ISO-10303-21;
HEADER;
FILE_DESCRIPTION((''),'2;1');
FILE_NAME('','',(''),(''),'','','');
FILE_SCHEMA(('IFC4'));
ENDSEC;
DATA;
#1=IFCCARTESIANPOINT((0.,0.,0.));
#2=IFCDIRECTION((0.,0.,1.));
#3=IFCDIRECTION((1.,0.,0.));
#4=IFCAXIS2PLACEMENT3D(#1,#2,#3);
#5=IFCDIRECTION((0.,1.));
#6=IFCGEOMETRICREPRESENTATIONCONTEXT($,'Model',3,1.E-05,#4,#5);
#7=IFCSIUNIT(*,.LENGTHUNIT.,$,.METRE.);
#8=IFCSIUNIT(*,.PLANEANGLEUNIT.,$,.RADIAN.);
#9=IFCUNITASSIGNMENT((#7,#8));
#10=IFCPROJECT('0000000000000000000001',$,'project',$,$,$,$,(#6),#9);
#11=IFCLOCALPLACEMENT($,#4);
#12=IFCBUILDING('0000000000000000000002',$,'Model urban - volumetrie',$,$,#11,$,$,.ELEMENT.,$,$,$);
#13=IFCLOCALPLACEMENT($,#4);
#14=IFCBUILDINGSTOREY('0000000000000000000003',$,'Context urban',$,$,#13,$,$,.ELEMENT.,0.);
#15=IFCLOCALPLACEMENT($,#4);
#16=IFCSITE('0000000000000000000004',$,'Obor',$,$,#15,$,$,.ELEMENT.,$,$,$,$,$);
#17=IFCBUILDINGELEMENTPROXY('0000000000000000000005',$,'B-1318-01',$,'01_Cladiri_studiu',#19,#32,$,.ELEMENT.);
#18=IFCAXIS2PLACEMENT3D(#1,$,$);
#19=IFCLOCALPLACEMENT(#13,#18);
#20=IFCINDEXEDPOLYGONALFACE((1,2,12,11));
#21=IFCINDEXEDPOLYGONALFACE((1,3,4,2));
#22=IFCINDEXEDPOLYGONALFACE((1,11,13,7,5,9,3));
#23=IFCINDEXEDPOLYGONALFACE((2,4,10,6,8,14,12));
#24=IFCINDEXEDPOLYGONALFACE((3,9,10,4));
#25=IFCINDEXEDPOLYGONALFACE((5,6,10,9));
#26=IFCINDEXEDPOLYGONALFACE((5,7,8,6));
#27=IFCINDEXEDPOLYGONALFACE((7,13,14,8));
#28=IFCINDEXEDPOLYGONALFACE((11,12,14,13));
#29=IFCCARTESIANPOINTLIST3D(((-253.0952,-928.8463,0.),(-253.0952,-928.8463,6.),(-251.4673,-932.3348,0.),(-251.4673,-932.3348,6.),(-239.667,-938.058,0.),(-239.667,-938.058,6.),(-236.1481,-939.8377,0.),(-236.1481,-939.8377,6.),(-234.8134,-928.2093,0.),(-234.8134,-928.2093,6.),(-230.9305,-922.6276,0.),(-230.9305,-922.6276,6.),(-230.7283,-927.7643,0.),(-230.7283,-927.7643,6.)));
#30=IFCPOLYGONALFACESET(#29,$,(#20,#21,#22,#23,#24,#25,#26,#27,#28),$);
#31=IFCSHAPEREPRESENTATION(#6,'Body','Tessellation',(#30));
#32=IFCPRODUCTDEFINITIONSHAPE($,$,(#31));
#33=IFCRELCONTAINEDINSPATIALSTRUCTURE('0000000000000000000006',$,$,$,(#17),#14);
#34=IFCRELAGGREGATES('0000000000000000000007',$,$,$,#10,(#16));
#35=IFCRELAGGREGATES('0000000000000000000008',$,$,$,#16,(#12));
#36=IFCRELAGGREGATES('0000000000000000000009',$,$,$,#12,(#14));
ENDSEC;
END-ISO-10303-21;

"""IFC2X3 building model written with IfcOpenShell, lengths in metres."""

from ifc_helpers import new_model, si_unit, direction, origin_with_axes, place, context, project, spatial, polyline, outline, extrude, element, save


model = new_model("IFC2X3")

# Units and contexts
model_context = context("Model", 3, precision=1e-05, world=origin_with_axes(), true_north=direction((0.0, 1.0)))
ifc_project = project(units=[si_unit("LENGTHUNIT", "METRE"), si_unit("PLANEANGLEUNIT", "RADIAN")], contexts=[model_context])

# Site, building, storey
site_placement = place(None, origin_with_axes())
site = spatial("IfcSite", under=ifc_project, at=site_placement, Name="Obor", CompositionType="ELEMENT")
building_placement = place(None, origin_with_axes())
building = spatial("IfcBuilding", under=site, at=building_placement, Name="Model urban - volumetrie", CompositionType="ELEMENT")
storey_placement = place(None, origin_with_axes())
storey = spatial("IfcBuildingStorey", under=building, at=storey_placement, Name="Context urban", CompositionType="ELEMENT", Elevation=0.0)

# Building element proxy
proxy_1_placement = place(None, origin_with_axes())
element("IfcBuildingElementProxy", 1, at=proxy_1_placement, inside=storey, Name="B-1318-01", ObjectType="01_Cladiri_studiu", CompositionType="ELEMENT", context=model_context, shape_type="SweptSolid", body=[
    extrude(outline(polyline([(-253.0952, -928.8463), (-251.4673, -932.3348), (-234.8134, -928.2093), (-239.667, -938.058), (-236.1481, -939.8377), (-230.7283, -927.7643), (-230.9305, -922.6276), (-253.0952, -928.8463)])), origin_with_axes(), (0.0, 0.0, 1.0), 6.0),
])

save(model, "model.ifc")
